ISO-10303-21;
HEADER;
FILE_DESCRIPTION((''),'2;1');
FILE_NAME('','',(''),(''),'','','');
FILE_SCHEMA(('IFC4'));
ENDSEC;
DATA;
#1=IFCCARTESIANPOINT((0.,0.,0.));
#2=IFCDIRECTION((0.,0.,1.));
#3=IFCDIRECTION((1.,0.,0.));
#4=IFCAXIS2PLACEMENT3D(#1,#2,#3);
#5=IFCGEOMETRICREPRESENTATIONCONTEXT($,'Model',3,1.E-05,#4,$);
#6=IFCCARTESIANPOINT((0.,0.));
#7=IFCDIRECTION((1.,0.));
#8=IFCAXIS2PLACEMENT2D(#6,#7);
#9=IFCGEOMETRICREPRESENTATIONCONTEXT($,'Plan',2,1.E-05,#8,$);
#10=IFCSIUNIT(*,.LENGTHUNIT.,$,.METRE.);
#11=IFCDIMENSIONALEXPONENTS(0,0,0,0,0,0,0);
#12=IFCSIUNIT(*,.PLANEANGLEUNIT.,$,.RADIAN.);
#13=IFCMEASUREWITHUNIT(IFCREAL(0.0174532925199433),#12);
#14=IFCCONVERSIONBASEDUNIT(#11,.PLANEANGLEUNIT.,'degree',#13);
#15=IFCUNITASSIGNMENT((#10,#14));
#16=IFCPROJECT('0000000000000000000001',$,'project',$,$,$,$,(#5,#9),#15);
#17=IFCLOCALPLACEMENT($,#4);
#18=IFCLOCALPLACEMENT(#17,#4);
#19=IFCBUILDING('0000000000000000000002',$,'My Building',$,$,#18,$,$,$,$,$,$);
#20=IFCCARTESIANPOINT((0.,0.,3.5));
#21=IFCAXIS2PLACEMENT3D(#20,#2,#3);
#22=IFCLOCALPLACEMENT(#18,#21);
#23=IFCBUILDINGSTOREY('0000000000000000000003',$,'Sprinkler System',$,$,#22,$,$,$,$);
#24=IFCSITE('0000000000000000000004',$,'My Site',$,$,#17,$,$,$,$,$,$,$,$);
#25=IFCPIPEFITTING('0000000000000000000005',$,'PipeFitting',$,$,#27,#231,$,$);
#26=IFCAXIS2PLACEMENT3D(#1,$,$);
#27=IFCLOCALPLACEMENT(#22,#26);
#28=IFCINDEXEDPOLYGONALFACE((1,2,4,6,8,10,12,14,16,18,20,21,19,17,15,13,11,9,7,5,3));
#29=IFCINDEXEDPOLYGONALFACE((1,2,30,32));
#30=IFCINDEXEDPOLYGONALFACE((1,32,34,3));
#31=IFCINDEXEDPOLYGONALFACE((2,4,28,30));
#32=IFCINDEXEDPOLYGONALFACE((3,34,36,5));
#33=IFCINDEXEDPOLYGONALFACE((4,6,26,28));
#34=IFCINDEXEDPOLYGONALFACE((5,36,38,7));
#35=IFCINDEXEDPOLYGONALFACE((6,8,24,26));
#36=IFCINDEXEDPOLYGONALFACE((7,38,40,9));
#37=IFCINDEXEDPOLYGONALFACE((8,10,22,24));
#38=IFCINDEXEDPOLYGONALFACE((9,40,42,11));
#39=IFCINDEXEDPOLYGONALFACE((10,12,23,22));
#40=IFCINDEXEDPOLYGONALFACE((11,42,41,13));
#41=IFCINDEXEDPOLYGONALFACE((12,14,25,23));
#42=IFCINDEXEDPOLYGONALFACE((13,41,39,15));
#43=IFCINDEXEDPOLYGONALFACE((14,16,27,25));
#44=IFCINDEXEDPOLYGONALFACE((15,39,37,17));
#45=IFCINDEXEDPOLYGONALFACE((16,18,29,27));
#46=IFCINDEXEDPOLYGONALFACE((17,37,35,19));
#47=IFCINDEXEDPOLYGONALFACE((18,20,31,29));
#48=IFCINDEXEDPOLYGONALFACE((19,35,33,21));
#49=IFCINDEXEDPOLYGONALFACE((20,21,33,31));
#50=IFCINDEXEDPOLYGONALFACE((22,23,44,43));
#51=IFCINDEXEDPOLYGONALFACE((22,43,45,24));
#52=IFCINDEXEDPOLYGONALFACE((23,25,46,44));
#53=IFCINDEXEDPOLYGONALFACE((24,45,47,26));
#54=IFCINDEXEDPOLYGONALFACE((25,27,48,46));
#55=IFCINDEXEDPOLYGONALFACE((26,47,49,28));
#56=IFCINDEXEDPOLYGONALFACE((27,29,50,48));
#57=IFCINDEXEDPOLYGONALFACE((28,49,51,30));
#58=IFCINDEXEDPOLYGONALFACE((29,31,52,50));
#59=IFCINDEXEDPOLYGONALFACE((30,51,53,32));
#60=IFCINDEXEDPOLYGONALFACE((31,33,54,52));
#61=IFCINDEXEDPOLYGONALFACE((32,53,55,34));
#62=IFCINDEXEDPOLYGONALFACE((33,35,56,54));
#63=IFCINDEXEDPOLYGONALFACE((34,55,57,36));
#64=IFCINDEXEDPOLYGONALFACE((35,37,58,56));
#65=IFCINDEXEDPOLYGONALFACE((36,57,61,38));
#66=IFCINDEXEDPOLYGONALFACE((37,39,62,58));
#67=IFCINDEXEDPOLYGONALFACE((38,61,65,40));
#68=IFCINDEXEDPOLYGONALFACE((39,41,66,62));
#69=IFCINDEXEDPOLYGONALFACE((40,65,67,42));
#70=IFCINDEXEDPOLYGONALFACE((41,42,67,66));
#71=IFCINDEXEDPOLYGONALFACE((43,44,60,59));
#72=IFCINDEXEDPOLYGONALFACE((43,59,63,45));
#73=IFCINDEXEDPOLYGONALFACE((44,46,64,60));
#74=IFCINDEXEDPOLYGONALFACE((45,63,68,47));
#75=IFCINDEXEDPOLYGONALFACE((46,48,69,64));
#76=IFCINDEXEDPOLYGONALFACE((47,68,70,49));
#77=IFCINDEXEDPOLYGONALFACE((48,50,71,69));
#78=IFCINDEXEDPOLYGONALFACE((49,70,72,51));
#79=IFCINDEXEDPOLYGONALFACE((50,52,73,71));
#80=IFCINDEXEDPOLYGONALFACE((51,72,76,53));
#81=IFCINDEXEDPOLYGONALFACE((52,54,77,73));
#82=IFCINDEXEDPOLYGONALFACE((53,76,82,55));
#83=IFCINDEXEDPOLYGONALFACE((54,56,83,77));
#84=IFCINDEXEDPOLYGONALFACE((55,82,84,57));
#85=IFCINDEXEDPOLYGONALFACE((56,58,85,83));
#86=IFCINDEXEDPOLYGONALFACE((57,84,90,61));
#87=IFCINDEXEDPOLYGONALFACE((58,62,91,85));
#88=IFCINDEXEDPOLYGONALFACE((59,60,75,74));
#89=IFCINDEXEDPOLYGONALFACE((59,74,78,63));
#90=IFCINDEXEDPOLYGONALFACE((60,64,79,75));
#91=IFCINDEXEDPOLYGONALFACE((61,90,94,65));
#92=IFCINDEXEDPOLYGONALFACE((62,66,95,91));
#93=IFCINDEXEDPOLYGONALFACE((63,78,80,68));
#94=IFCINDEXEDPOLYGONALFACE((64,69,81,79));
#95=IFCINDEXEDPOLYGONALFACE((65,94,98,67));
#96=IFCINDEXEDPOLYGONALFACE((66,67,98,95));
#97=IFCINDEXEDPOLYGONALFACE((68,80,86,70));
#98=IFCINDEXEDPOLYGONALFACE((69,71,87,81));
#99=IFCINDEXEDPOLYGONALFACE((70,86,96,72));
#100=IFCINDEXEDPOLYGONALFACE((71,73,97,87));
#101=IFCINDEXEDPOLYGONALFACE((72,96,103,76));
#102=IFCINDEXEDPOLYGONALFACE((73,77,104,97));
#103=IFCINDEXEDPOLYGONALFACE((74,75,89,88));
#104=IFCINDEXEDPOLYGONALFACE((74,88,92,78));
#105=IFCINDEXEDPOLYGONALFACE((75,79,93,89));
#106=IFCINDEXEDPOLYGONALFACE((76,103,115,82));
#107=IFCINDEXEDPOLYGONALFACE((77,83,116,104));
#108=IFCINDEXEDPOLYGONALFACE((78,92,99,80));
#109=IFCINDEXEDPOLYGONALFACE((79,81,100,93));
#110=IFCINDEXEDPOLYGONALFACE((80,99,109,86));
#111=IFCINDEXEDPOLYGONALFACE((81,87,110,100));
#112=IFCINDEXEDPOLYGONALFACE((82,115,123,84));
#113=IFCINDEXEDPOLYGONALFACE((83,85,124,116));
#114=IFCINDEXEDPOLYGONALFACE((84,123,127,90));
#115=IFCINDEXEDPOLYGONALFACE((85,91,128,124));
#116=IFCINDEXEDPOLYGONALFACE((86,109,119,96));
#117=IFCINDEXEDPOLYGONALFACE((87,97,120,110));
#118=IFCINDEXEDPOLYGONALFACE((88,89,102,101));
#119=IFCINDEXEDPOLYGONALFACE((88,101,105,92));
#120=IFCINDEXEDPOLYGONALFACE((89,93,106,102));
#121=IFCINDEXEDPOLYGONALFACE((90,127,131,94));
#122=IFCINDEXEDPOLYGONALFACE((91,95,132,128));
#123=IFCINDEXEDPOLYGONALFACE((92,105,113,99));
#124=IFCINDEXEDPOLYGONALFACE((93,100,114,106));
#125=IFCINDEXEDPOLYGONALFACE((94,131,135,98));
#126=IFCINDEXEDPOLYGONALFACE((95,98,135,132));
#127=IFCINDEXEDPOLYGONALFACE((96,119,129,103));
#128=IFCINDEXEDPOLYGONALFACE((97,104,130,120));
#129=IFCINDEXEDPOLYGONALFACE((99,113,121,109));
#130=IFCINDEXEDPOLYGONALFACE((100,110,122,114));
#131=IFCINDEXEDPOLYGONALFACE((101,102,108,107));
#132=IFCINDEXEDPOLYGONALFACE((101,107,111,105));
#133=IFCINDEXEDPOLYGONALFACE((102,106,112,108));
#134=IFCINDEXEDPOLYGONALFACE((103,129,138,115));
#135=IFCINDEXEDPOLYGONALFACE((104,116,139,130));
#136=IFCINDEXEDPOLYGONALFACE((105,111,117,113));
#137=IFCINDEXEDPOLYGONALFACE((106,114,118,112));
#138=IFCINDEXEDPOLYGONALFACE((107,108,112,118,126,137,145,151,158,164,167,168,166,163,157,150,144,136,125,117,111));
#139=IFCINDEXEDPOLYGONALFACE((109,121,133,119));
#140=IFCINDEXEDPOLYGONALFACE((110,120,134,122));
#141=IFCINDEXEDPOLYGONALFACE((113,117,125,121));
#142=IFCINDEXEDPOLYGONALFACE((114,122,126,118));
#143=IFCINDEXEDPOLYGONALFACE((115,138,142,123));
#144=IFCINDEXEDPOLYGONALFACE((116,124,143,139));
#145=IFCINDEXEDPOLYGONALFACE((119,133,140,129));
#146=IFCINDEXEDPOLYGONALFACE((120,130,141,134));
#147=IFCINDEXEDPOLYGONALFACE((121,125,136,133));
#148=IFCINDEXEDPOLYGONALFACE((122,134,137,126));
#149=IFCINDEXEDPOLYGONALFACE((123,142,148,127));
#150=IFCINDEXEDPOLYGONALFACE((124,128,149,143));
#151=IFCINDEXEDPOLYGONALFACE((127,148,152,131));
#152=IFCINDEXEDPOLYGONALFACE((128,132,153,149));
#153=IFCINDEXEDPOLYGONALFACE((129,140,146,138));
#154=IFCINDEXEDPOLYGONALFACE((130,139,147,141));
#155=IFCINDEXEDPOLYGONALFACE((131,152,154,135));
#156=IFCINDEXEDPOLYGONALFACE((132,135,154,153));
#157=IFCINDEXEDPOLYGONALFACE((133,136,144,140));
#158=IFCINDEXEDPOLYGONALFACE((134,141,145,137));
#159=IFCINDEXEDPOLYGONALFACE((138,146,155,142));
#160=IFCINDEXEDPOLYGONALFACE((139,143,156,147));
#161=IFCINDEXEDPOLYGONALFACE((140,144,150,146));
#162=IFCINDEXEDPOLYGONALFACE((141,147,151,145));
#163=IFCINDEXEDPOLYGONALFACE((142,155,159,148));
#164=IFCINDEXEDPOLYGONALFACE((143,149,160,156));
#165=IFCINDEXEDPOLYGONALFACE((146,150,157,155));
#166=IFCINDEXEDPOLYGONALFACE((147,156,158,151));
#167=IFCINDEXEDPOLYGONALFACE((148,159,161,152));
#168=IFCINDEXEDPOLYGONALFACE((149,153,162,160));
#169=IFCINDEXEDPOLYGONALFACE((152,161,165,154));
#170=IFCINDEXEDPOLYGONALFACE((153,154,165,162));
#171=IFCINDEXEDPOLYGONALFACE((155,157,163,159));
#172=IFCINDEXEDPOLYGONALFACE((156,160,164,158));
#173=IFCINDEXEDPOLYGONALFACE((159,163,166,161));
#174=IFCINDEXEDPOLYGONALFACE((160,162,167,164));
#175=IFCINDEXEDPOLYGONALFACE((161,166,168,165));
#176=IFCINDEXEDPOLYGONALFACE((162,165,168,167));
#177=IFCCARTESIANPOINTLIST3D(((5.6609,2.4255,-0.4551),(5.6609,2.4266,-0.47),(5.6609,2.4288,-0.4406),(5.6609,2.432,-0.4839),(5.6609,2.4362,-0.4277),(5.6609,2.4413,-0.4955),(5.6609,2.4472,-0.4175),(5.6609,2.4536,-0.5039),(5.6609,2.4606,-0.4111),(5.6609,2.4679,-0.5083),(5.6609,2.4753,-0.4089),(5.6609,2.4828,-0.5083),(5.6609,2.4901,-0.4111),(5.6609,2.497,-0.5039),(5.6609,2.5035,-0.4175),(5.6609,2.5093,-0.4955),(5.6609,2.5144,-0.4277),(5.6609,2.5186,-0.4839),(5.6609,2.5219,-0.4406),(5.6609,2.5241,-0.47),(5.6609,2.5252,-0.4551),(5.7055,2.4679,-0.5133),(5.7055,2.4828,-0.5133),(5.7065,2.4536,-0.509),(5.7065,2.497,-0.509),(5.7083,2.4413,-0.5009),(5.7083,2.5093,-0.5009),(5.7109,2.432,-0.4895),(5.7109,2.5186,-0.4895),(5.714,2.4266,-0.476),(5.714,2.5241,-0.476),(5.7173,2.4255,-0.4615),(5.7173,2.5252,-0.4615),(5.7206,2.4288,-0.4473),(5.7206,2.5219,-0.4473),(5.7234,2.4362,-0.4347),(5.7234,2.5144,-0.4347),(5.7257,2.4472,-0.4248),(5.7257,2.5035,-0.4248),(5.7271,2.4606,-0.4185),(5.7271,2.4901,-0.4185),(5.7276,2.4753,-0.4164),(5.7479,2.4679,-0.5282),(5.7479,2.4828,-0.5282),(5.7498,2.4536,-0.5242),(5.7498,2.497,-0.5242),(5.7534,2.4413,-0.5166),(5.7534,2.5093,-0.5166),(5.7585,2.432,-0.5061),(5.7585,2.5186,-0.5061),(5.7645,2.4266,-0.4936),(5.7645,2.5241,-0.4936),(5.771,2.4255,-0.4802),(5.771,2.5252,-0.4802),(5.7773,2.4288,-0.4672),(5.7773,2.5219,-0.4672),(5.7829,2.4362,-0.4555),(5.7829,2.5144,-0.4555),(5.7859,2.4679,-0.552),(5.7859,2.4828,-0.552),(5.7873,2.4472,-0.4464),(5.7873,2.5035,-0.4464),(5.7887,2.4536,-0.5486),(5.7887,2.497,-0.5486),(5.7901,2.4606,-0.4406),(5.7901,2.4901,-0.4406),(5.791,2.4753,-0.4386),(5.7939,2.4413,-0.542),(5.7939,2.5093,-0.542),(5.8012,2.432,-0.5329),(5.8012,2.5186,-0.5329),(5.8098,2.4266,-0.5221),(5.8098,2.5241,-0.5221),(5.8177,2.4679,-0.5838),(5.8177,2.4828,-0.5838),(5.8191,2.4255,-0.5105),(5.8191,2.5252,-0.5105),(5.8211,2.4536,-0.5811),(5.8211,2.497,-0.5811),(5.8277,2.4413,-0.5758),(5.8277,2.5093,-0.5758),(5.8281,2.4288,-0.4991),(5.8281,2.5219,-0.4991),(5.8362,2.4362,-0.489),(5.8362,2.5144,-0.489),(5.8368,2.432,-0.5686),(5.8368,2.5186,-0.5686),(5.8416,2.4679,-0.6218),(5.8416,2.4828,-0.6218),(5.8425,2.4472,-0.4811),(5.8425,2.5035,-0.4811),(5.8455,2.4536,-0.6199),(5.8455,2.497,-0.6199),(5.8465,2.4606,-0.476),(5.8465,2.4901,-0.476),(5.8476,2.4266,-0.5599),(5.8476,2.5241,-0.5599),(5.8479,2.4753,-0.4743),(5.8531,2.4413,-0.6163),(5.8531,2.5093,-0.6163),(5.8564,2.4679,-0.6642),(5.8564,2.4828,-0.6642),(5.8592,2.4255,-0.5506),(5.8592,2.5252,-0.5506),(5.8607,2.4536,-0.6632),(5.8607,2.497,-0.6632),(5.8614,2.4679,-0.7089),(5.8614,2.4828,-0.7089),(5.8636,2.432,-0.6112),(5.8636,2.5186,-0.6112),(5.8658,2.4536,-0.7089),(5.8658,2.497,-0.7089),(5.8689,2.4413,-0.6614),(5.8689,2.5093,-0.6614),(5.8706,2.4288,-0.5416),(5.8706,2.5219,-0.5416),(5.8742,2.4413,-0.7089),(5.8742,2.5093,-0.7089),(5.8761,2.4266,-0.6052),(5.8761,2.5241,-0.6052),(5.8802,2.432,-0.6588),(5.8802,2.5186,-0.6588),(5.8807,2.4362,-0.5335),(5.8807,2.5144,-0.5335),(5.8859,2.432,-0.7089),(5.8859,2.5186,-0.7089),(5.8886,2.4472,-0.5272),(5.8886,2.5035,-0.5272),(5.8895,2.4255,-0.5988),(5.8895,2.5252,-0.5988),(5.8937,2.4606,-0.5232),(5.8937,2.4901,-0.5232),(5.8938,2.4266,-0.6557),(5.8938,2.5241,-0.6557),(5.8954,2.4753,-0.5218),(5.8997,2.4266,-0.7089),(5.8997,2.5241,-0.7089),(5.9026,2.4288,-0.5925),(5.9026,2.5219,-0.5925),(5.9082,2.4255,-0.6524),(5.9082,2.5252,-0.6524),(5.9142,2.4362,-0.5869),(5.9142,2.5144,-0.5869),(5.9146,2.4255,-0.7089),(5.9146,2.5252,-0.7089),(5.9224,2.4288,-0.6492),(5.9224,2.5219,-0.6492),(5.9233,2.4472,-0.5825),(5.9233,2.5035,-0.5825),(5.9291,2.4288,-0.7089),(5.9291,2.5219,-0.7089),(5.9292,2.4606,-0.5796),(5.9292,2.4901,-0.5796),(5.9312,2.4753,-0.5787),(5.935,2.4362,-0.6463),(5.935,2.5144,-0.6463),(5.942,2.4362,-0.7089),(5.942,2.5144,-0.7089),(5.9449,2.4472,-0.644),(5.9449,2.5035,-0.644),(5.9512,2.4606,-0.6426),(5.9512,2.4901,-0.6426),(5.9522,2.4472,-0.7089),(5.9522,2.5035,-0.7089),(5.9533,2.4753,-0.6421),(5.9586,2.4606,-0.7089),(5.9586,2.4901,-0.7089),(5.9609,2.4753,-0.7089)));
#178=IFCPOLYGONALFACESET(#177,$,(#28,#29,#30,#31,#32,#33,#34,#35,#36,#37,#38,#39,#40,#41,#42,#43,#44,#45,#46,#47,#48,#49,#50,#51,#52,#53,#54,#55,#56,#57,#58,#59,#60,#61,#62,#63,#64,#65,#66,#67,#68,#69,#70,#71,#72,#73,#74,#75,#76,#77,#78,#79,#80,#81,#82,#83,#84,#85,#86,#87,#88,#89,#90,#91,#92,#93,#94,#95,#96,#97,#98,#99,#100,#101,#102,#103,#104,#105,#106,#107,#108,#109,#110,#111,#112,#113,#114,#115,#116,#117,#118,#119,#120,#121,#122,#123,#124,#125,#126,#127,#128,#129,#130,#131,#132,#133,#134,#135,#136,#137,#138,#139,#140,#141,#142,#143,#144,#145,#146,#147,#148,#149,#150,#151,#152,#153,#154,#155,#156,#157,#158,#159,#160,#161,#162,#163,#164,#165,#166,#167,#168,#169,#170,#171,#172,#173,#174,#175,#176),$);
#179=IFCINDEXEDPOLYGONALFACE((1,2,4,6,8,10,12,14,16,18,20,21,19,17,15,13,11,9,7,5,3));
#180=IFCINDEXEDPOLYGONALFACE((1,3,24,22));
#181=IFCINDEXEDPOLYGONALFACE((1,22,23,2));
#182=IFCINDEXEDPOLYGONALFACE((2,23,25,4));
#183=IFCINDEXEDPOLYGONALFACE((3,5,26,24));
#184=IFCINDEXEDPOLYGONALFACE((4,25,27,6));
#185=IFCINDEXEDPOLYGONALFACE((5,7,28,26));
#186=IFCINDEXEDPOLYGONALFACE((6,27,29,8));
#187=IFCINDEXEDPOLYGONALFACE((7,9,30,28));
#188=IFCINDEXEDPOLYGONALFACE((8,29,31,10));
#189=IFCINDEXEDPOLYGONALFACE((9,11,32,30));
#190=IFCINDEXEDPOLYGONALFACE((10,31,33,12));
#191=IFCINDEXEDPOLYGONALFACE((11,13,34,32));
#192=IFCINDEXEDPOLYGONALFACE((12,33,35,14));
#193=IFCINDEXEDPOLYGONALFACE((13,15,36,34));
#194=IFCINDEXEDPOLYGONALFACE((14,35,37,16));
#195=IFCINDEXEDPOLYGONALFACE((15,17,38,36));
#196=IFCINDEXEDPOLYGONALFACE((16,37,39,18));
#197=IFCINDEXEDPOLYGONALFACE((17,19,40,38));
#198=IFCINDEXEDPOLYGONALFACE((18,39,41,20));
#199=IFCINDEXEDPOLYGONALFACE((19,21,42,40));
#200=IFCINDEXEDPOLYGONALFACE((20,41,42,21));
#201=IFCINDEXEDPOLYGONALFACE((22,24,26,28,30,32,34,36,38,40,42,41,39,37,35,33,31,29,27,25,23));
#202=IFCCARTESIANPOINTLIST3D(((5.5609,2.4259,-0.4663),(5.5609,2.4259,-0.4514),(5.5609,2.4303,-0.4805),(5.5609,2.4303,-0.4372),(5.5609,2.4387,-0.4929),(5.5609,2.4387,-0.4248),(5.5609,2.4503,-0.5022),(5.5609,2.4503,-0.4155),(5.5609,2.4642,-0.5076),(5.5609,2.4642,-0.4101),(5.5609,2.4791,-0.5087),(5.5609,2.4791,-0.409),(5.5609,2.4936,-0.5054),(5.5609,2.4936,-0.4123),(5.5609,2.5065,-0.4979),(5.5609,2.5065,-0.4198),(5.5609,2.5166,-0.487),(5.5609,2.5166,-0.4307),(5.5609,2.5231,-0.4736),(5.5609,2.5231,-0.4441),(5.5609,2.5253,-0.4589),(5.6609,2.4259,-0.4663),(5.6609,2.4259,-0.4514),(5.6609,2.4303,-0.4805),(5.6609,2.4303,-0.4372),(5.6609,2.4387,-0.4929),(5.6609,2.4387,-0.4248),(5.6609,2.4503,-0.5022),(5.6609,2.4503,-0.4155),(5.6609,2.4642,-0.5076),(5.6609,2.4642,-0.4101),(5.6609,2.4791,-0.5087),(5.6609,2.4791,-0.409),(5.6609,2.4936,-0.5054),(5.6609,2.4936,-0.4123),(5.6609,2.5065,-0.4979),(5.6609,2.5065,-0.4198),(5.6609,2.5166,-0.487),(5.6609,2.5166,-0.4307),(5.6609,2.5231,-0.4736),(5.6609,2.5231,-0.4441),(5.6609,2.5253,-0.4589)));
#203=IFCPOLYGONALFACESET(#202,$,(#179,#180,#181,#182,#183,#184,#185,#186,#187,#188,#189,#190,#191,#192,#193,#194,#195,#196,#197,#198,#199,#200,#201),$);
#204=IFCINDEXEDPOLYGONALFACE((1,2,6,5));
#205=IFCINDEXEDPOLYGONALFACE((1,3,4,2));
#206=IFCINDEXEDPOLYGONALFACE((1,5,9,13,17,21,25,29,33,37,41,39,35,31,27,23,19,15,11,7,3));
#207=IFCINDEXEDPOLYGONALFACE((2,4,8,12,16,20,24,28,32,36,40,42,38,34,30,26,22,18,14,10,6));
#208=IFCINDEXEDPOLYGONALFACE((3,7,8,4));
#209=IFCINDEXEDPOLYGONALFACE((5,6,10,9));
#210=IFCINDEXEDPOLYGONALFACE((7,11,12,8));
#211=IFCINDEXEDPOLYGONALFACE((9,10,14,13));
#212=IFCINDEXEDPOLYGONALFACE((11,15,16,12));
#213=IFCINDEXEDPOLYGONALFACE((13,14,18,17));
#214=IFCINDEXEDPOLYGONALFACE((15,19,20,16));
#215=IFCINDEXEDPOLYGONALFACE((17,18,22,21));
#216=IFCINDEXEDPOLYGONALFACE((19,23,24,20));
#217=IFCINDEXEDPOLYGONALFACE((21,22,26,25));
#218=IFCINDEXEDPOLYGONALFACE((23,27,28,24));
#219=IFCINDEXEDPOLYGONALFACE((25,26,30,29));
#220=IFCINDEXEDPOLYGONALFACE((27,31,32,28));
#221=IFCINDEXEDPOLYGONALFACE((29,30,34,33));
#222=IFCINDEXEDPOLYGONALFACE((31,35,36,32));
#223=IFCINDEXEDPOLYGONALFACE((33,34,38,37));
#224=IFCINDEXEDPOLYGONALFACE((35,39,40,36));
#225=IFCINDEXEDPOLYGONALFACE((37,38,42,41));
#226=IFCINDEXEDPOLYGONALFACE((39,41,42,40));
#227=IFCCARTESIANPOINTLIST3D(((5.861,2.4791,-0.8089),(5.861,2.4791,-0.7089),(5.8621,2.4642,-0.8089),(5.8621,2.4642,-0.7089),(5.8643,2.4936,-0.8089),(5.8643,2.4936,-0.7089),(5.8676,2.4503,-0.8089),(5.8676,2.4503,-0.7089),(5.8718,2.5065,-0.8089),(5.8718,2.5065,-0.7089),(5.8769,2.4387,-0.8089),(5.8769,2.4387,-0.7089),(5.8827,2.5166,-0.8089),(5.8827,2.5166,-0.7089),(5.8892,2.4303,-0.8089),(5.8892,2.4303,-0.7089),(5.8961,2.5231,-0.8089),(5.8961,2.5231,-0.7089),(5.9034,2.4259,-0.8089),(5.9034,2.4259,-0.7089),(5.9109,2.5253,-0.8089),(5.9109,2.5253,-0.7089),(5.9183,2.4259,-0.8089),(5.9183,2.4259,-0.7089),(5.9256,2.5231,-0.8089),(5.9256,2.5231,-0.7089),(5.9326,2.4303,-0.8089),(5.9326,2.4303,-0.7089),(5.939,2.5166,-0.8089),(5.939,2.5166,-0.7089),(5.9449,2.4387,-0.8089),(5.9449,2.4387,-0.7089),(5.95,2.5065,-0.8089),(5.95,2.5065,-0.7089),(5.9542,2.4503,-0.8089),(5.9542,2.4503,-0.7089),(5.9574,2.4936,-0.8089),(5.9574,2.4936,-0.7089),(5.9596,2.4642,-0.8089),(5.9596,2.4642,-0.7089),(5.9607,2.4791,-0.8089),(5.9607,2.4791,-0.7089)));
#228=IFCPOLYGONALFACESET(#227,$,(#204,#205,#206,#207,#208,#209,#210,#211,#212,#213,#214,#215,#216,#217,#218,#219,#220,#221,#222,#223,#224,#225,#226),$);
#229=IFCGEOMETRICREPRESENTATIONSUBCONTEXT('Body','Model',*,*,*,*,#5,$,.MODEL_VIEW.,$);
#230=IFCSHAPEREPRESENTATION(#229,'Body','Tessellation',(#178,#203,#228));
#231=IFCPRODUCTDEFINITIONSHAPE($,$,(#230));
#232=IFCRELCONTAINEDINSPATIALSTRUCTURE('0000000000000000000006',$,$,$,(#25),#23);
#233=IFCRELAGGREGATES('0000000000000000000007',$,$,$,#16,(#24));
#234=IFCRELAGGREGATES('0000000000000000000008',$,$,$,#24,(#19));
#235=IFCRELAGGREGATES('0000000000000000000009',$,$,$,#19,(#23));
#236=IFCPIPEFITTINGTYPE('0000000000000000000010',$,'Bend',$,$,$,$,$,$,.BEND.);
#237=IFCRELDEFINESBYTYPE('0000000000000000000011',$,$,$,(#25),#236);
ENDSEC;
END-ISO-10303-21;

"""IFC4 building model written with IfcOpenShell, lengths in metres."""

from ifc_helpers import new_model, entity, si_unit, converted_unit, frame, origin_with_axes, origin_2d_with_axis, place, context, subcontext, project, spatial, circle, extrude, source, transform, mapped, type_object, type_shapes, element, save


model = new_model("IFC4")

# Units and contexts
model_context = context("Model", 3, precision=1e-05, world=origin_with_axes())
plan_context = context("Plan", 2, precision=1e-05, world=origin_2d_with_axis())
body_context = subcontext(model_context, "Body", "Model", "MODEL_VIEW")
ifc_project = project(units=[si_unit("LENGTHUNIT", "METRE"), converted_unit("PLANEANGLEUNIT", "degree", entity("IfcReal", 0.0174532925199433), si_unit("PLANEANGLEUNIT", "RADIAN"), dimensions=[0, 0, 0, 0, 0, 0, 0])], contexts=[model_context, plan_context])

# Site, building, storey
site_placement = place(None, origin_with_axes())
site = spatial("IfcSite", under=ifc_project, at=site_placement, Name="My Site")
building_placement = place(site_placement, origin_with_axes())
building = spatial("IfcBuilding", under=site, at=building_placement, Name="My Building")
storey_placement = place(building_placement, frame((0.0, 0.0, 3.5), z_axis=(0.0, 0.0, 1.0), x_axis=(1.0, 0.0, 0.0)))
storey = spatial("IfcBuildingStorey", under=building, at=storey_placement, Name="Sprinkler System")

# Pipe fitting
pipe_fitting_type_1 = type_object("IfcPipeFittingType", Name="Bend", PredefinedType="BEND")
shared_shape_1 = source(origin_with_axes(), body_context, "Body", "SolidModel", [
    entity("IfcSweptDiskSolid", entity("IfcIndexedPolyCurve", entity("IfcCartesianPointList3D", [[0.0, 0.0, 0.1], [0.0, -0.0732, 0.2768], [0.0, -0.25, 0.35]]), [entity("IfcArcIndex", [1, 2, 3])]), 0.05),
    extrude(circle(Radius=0.05), origin_with_axes(), (0.0, 0.0, 1.0), 0.1),
    extrude(circle(Radius=0.05), frame((0.0, -0.25, 0.35), z_axis=(0.0, -1.0, 0.0), x_axis=(1.0, 0.0, 0.0)), (0.0, 0.0, 1.0), 0.1),
])
type_shapes(pipe_fitting_type_1, [shared_shape_1])
for number, where, z_axis, x_axis, name in (
    (1, (5.5609, 2.4753, -0.4589), (1.0, 0.0, 0.0), (0.0, 1.0, 0.0), "PipeFitting"),
):
    element("IfcPipeFitting", number, at=place(storey_placement, frame(where, z_axis=z_axis, x_axis=x_axis)), inside=storey, type_object=pipe_fitting_type_1, Name=name, context=body_context, shape_type="MappedRepresentation", body=[
        mapped(shared_shape_1, transform((0.0, 0.0, 0.0), x_axis=(1.0, 0.0, 0.0), y_axis=(0.0, 1.0, 0.0), z_axis=(0.0, 0.0, 1.0), scale=1.0)),
    ])

save(model, "model.ifc")
